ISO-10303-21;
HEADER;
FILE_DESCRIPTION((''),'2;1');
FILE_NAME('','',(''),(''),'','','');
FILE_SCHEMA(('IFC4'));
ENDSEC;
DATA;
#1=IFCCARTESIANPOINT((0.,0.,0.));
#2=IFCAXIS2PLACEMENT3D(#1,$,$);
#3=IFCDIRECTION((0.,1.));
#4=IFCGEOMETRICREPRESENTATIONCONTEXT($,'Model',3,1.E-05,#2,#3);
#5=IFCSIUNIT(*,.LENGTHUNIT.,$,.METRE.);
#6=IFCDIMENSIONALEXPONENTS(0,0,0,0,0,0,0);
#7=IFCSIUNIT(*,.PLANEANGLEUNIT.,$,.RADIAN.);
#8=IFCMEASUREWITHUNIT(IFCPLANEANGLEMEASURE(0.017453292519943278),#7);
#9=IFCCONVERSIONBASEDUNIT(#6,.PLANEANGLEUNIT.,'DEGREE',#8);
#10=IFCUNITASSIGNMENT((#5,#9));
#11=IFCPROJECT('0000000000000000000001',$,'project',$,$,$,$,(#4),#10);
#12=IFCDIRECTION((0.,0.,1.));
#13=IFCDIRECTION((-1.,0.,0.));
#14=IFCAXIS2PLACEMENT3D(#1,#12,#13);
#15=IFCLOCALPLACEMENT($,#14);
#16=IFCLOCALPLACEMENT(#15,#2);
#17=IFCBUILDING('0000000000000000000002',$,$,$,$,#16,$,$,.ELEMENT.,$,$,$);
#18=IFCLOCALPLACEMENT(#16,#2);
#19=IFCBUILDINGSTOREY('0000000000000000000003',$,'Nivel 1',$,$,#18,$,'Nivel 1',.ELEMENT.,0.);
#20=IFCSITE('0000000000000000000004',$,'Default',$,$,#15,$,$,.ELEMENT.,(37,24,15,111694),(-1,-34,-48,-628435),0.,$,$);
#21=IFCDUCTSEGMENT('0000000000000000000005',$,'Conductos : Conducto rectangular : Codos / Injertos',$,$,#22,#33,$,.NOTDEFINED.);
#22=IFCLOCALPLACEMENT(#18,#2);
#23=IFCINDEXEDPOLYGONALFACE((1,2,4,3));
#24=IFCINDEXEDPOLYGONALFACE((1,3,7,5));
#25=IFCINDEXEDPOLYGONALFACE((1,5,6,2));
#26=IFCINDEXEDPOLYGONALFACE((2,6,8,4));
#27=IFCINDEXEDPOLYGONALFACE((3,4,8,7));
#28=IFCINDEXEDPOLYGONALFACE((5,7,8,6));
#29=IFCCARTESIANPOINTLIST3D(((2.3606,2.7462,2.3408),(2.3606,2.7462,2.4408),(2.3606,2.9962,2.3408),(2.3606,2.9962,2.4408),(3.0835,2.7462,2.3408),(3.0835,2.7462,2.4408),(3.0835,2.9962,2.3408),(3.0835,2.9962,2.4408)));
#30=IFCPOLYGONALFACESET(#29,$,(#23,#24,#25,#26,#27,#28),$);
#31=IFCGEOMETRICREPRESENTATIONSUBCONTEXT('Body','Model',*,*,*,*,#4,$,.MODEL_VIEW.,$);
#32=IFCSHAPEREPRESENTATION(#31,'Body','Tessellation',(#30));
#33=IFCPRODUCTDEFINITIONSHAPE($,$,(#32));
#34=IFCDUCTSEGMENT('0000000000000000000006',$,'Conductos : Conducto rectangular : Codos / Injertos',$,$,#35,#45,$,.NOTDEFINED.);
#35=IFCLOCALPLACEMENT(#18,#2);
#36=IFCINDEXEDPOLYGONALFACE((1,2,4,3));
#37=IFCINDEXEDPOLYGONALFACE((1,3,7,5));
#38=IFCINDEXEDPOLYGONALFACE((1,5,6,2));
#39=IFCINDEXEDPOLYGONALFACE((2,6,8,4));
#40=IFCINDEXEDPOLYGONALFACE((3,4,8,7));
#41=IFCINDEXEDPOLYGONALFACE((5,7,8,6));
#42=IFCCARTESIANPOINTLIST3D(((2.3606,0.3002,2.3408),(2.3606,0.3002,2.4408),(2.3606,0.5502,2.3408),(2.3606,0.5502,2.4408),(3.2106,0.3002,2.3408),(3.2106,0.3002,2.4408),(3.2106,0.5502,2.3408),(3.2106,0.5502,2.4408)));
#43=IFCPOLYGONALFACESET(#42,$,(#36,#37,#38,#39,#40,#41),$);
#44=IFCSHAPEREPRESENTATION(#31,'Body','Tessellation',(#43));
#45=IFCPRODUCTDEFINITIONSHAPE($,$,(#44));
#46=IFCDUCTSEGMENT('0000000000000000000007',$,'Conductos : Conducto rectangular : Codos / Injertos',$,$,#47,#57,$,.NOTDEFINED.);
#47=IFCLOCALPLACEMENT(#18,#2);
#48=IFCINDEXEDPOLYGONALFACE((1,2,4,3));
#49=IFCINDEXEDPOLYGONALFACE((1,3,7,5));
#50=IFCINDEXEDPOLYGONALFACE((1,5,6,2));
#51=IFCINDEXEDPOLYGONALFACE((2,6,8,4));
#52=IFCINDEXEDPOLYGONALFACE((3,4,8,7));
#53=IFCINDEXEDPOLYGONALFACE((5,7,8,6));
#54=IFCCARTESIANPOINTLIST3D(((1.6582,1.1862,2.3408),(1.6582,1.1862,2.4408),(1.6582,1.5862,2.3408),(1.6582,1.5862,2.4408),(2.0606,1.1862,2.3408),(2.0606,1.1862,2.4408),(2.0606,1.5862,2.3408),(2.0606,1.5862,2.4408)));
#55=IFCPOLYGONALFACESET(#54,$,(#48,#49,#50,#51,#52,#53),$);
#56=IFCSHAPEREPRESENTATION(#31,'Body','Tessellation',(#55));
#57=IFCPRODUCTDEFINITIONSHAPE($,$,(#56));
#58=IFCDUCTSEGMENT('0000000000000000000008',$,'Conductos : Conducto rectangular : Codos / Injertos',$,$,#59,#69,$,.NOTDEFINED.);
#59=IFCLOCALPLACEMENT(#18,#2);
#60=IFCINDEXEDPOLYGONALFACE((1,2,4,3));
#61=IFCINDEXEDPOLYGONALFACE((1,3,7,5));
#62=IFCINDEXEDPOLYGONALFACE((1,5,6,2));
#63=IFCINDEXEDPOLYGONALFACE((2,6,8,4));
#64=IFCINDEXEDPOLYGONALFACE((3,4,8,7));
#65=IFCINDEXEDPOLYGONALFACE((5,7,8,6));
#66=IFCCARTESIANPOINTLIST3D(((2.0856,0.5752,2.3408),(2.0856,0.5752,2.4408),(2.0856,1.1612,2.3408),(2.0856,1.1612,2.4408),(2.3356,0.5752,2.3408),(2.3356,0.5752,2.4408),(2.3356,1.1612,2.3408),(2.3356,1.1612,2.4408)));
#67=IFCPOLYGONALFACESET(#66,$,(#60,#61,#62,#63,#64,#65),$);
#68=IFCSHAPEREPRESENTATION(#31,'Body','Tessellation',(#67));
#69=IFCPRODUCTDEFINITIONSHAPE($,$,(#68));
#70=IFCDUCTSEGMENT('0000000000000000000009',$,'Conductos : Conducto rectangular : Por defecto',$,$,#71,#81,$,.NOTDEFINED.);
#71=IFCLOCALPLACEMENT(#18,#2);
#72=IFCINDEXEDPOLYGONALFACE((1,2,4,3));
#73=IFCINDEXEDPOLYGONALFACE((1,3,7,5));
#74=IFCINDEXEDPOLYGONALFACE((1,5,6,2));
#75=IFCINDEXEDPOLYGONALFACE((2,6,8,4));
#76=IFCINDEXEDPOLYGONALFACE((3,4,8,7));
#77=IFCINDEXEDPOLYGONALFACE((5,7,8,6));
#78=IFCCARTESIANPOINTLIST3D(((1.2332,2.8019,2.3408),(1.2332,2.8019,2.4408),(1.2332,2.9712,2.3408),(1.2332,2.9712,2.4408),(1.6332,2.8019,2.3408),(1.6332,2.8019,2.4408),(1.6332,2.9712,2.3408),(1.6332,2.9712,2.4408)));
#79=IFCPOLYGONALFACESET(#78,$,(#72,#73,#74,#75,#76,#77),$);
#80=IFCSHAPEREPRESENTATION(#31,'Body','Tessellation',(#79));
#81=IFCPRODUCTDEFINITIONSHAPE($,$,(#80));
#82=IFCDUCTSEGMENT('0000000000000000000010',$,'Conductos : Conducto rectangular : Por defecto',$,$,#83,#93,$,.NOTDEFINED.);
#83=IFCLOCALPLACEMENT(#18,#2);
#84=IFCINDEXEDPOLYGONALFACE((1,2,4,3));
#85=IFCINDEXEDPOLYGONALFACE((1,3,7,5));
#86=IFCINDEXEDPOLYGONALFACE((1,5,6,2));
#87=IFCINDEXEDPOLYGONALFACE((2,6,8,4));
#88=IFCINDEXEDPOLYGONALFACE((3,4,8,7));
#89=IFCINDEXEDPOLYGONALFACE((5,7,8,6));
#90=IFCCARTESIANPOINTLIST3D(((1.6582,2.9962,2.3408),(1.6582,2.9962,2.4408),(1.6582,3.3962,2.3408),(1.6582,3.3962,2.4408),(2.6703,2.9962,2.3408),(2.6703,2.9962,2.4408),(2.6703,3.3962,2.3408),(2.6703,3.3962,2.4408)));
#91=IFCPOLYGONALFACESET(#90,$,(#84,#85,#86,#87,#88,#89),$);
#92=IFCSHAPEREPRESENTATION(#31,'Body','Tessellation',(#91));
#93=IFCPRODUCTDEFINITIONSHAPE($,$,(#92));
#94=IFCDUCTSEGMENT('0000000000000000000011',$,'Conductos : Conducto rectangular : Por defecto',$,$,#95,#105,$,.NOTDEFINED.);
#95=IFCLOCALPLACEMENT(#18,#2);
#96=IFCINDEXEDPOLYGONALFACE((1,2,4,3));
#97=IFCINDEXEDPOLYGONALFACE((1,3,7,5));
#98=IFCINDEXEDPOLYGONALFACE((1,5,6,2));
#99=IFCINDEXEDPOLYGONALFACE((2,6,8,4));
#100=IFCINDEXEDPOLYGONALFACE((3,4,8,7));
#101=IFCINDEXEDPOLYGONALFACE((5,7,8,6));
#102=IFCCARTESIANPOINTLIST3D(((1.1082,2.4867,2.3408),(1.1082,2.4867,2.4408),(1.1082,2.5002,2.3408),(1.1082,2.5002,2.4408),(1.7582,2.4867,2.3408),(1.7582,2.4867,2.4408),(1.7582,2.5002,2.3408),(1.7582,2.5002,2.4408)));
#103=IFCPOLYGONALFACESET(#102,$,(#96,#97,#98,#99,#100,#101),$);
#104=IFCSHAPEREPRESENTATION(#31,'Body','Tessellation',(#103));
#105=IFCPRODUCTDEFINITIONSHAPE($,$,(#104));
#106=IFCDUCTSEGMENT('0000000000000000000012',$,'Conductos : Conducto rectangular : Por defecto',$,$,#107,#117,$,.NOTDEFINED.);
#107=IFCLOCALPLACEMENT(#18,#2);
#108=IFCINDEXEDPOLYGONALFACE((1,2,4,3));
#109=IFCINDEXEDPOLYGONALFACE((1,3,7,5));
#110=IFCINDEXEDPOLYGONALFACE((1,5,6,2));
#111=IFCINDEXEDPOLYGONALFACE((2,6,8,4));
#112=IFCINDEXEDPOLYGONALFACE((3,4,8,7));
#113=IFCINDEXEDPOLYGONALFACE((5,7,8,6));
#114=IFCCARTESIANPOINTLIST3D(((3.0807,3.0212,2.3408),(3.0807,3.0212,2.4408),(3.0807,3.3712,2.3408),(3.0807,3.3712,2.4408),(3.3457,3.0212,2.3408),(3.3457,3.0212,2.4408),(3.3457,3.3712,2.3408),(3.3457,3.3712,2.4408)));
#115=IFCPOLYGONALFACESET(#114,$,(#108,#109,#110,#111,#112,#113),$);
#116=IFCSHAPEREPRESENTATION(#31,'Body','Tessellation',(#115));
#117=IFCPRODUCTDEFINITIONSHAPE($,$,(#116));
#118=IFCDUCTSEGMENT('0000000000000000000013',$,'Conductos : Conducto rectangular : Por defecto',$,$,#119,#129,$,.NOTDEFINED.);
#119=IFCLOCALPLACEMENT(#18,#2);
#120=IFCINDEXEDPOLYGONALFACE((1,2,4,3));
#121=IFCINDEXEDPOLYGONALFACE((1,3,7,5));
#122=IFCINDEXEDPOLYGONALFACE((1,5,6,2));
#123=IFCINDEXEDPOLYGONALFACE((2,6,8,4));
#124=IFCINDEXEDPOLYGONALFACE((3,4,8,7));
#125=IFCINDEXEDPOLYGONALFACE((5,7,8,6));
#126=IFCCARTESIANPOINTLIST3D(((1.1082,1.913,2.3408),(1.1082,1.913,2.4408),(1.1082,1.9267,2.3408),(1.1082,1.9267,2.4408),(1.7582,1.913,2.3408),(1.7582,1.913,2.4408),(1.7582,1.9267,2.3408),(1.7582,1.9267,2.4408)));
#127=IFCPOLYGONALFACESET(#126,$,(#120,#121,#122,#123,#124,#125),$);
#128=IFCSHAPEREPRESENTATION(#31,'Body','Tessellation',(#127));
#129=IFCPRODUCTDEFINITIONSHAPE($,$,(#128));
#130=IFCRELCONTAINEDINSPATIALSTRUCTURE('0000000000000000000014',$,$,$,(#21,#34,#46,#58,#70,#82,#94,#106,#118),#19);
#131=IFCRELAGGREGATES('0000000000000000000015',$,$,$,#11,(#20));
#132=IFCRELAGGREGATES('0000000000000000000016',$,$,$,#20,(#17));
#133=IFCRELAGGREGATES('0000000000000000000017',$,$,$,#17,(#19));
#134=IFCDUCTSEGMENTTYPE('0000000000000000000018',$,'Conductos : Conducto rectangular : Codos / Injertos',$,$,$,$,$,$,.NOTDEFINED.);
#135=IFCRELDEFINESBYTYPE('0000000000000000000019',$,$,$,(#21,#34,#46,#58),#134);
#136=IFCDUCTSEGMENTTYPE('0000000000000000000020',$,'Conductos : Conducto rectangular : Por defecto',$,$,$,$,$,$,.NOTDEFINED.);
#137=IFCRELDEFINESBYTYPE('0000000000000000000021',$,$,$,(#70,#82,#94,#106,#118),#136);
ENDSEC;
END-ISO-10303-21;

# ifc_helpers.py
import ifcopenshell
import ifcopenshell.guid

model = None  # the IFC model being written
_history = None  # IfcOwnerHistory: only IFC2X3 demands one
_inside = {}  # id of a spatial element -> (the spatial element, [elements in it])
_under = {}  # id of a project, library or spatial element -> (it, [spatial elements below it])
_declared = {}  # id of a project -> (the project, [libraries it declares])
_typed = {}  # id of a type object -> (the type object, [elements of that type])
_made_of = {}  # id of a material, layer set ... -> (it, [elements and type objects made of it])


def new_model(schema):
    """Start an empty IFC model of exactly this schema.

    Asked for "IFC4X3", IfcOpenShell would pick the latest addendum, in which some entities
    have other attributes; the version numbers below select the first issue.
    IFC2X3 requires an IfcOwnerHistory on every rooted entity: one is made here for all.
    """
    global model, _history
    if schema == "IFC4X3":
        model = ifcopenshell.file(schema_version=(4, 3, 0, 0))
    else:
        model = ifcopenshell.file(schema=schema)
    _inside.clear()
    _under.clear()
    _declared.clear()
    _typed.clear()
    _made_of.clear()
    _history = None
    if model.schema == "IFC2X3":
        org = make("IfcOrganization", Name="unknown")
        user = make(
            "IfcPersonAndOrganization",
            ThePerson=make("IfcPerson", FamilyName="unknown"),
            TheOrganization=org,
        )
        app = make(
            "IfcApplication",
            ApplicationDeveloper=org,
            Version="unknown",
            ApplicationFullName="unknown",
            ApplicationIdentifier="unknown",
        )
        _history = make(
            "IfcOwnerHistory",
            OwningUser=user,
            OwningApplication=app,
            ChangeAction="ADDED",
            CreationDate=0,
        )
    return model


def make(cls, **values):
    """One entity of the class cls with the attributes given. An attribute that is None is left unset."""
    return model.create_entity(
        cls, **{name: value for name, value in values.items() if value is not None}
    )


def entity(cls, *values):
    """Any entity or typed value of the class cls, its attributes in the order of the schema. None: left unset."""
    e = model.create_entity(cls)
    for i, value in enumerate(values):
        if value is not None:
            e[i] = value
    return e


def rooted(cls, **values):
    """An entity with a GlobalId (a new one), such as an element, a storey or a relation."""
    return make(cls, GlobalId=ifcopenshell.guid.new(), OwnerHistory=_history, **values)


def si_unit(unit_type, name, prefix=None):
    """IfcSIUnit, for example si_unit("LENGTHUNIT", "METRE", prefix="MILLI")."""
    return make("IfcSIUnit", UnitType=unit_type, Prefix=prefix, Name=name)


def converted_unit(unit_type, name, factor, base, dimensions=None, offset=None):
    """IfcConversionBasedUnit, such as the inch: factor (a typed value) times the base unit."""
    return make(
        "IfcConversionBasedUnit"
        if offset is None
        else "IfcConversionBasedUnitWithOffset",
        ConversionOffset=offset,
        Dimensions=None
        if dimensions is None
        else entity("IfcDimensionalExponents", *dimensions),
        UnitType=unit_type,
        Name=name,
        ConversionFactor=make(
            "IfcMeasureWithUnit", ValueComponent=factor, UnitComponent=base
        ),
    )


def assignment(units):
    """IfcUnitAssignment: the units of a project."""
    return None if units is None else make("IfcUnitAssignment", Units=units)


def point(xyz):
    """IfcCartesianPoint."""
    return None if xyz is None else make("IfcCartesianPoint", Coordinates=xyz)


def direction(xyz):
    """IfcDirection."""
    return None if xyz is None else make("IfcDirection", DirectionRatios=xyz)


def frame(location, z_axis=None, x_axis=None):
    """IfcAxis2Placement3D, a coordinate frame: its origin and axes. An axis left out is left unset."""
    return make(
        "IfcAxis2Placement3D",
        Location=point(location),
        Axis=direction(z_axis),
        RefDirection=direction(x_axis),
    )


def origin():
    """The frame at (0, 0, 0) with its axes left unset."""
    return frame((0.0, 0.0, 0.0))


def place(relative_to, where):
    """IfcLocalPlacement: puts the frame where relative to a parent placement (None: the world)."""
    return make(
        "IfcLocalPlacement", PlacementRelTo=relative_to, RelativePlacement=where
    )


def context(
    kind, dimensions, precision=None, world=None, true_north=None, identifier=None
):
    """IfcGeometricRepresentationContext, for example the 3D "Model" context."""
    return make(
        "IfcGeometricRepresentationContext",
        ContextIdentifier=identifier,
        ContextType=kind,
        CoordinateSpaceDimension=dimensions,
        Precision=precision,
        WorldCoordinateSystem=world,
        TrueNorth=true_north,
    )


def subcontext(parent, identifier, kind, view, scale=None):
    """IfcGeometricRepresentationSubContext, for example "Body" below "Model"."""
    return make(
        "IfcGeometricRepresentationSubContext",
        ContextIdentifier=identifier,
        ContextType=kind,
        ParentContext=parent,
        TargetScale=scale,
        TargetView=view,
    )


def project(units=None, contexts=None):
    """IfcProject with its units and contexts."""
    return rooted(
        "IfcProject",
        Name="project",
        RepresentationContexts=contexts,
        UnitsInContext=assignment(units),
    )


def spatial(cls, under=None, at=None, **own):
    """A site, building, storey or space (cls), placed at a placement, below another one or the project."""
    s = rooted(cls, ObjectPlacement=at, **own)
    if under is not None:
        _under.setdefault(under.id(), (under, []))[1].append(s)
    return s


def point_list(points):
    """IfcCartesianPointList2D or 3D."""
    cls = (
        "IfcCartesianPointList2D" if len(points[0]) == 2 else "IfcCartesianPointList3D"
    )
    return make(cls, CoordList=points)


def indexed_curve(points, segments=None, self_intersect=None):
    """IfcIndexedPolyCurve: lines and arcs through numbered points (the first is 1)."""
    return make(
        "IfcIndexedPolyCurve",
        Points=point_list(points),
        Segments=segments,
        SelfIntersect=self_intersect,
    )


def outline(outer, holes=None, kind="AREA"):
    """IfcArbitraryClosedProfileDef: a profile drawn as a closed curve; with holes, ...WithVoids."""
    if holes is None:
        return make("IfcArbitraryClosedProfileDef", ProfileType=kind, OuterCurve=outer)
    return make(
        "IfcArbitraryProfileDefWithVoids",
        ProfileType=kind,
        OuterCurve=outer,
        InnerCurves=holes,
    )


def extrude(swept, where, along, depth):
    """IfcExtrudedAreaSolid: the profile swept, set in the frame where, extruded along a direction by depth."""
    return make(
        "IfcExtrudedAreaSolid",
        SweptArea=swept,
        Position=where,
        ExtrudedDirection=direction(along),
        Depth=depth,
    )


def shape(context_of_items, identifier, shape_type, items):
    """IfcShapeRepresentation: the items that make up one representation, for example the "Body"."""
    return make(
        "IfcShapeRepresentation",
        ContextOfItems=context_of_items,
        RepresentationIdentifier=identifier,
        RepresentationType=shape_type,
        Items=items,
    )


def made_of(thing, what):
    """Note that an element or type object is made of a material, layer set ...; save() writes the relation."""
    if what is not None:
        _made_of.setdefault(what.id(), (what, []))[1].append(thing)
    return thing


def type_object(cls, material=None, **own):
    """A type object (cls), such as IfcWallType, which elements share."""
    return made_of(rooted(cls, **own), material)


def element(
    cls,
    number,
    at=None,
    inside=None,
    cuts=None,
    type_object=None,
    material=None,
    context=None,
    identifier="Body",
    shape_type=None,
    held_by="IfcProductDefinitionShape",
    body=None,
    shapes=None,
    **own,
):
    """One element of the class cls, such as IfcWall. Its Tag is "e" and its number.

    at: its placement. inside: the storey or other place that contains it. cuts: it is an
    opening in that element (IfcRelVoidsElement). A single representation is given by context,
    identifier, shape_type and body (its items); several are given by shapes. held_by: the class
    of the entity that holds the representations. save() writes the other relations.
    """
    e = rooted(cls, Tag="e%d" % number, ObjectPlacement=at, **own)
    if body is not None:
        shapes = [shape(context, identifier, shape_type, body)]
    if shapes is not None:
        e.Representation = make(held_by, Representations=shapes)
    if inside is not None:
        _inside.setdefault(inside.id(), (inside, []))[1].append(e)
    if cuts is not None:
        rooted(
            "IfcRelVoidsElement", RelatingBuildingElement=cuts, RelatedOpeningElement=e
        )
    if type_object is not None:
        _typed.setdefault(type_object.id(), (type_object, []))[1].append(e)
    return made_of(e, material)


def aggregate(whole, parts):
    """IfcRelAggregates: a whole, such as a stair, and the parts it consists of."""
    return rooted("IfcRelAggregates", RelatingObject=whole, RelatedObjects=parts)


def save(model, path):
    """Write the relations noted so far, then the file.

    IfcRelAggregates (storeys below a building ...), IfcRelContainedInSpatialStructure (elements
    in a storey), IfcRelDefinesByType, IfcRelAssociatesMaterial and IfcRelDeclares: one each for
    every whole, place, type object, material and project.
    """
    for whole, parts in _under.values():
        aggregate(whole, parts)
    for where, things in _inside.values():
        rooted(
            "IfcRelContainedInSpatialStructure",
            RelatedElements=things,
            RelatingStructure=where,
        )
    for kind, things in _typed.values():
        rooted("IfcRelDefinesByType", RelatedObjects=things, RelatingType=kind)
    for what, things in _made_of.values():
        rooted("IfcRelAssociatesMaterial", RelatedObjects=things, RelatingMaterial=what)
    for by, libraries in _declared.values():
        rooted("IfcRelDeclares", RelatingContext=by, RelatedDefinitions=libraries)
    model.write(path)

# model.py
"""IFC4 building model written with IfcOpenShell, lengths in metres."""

from ifc_helpers import new_model, entity, si_unit, converted_unit, direction, frame, origin, place, context, subcontext, project, spatial, indexed_curve, outline, extrude, type_object, element, save


model = new_model("IFC4")

# Units and contexts
model_context = context("Model", 3, precision=1e-05, world=origin(), true_north=direction((0.0, 1.0)))
body_context = subcontext(model_context, "Body", "Model", "MODEL_VIEW")
ifc_project = project(units=[si_unit("LENGTHUNIT", "METRE"), converted_unit("PLANEANGLEUNIT", "DEGREE", entity("IfcPlaneAngleMeasure", 0.017453292519943278), si_unit("PLANEANGLEUNIT", "RADIAN"), dimensions=[0, 0, 0, 0, 0, 0, 0])], contexts=[model_context])

# Site, building, storey
site_placement = place(None, frame((0.0, 0.0, 0.0), z_axis=(0.0, 0.0, 1.0), x_axis=(-1.0, 0.0, 0.0)))
site = spatial("IfcSite", under=ifc_project, at=site_placement, Name="Default", CompositionType="ELEMENT", RefLatitude=(37, 24, 15, 111694), RefLongitude=(-1, -34, -48, -628435), RefElevation=0.0)
building_placement = place(site_placement, origin())
building = spatial("IfcBuilding", under=site, at=building_placement, CompositionType="ELEMENT")
storey_placement = place(building_placement, origin())
storey = spatial("IfcBuildingStorey", under=building, at=storey_placement, Name="Nivel 1", LongName="Nivel 1", CompositionType="ELEMENT", Elevation=0.0)

# Duct segments
duct_segment_type_1 = type_object("IfcDuctSegmentType", Name="Conductos : Conducto rectangular : Codos / Injertos", PredefinedType="NOTDEFINED")
duct_segment_1_placement = place(storey_placement, origin())
element("IfcDuctSegment", 1, at=duct_segment_1_placement, inside=storey, type_object=duct_segment_type_1, Name="Conductos : Conducto rectangular : Codos / Injertos", PredefinedType="NOTDEFINED", context=body_context, shape_type="SweptSolid", body=[
    extrude(outline(indexed_curve([(-0.3614, -0.125), (0.3614, -0.125), (0.3614, 0.125), (-0.3614, 0.125), (-0.3614, -0.125)], self_intersect=False)), frame((2.7221, 2.8712, 2.3408)), (0.0, 0.0, 1.0), 0.1),
])
duct_segment_2_placement = place(storey_placement, origin())
element("IfcDuctSegment", 2, at=duct_segment_2_placement, inside=storey, type_object=duct_segment_type_1, Name="Conductos : Conducto rectangular : Codos / Injertos", PredefinedType="NOTDEFINED", context=body_context, shape_type="SweptSolid", body=[
    extrude(outline(indexed_curve([(-0.425, -0.125), (0.425, -0.125), (0.425, 0.125), (-0.425, 0.125), (-0.425, -0.125)], self_intersect=False)), frame((2.7856, 0.4252, 2.3408)), (0.0, 0.0, 1.0), 0.1),
])
duct_segment_3_placement = place(storey_placement, origin())
element("IfcDuctSegment", 3, at=duct_segment_3_placement, inside=storey, type_object=duct_segment_type_1, Name="Conductos : Conducto rectangular : Codos / Injertos", PredefinedType="NOTDEFINED", context=body_context, shape_type="SweptSolid", body=[
    extrude(outline(indexed_curve([(-0.2012, -0.2), (0.2012, -0.2), (0.2012, 0.2), (-0.2012, 0.2), (-0.2012, -0.2)], self_intersect=False)), frame((1.8594, 1.3862, 2.3408), z_axis=(0.0, 0.0, 1.0), x_axis=(-1.0, 0.0, 0.0)), (0.0, 0.0, 1.0), 0.1),
])
duct_segment_4_placement = place(storey_placement, origin())
element("IfcDuctSegment", 4, at=duct_segment_4_placement, inside=storey, type_object=duct_segment_type_1, Name="Conductos : Conducto rectangular : Codos / Injertos", PredefinedType="NOTDEFINED", context=body_context, shape_type="SweptSolid", body=[
    extrude(outline(indexed_curve([(-0.293, -0.125), (0.293, -0.125), (0.293, 0.125), (-0.293, 0.125), (-0.293, -0.125)], self_intersect=False)), frame((2.2106, 0.8682, 2.3408), z_axis=(0.0, 0.0, 1.0), x_axis=(0.0, 1.0, 0.0)), (0.0, 0.0, 1.0), 0.1),
])
duct_segment_type_2 = type_object("IfcDuctSegmentType", Name="Conductos : Conducto rectangular : Por defecto", PredefinedType="NOTDEFINED")
duct_segment_5_placement = place(storey_placement, origin())
element("IfcDuctSegment", 5, at=duct_segment_5_placement, inside=storey, type_object=duct_segment_type_2, Name="Conductos : Conducto rectangular : Por defecto", PredefinedType="NOTDEFINED", context=body_context, shape_type="SweptSolid", body=[
    extrude(outline(indexed_curve([(-0.0846, -0.2), (0.0846, -0.2), (0.0846, 0.2), (-0.0846, 0.2), (-0.0846, -0.2)], self_intersect=False)), frame((1.4332, 2.8866, 2.3408), z_axis=(0.0, 0.0, 1.0), x_axis=(0.0, -1.0, 0.0)), (0.0, 0.0, 1.0), 0.1),
])
duct_segment_6_placement = place(storey_placement, origin())
element("IfcDuctSegment", 6, at=duct_segment_6_placement, inside=storey, type_object=duct_segment_type_2, Name="Conductos : Conducto rectangular : Por defecto", PredefinedType="NOTDEFINED", context=body_context, shape_type="SweptSolid", body=[
    extrude(outline(indexed_curve([(-0.5061, -0.2), (0.5061, -0.2), (0.5061, 0.2), (-0.5061, 0.2), (-0.5061, -0.2)], self_intersect=False)), frame((2.1643, 3.1962, 2.3408)), (0.0, 0.0, 1.0), 0.1),
])
duct_segment_7_placement = place(storey_placement, origin())
element("IfcDuctSegment", 7, at=duct_segment_7_placement, inside=storey, type_object=duct_segment_type_2, Name="Conductos : Conducto rectangular : Por defecto", PredefinedType="NOTDEFINED", context=body_context, shape_type="SweptSolid", body=[
    extrude(outline(indexed_curve([(-0.0067, -0.325), (0.0067, -0.325), (0.0067, 0.325), (-0.0067, 0.325), (-0.0067, -0.325)], self_intersect=False)), frame((1.4332, 2.4934, 2.3408), z_axis=(0.0, 0.0, 1.0), x_axis=(0.0, -1.0, 0.0)), (0.0, 0.0, 1.0), 0.1),
])
duct_segment_8_placement = place(storey_placement, origin())
element("IfcDuctSegment", 8, at=duct_segment_8_placement, inside=storey, type_object=duct_segment_type_2, Name="Conductos : Conducto rectangular : Por defecto", PredefinedType="NOTDEFINED", context=body_context, shape_type="SweptSolid", body=[
    extrude(outline(indexed_curve([(-0.1325, -0.175), (0.1325, -0.175), (0.1325, 0.175), (-0.1325, 0.175), (-0.1325, -0.175)], self_intersect=False)), frame((3.2132, 3.1962, 2.3408)), (0.0, 0.0, 1.0), 0.1),
])
duct_segment_9_placement = place(storey_placement, origin())
element("IfcDuctSegment", 9, at=duct_segment_9_placement, inside=storey, type_object=duct_segment_type_2, Name="Conductos : Conducto rectangular : Por defecto", PredefinedType="NOTDEFINED", context=body_context, shape_type="SweptSolid", body=[
    extrude(outline(indexed_curve([(-0.0068, -0.325), (0.0068, -0.325), (0.0068, 0.325), (-0.0068, 0.325), (-0.0068, -0.325)], self_intersect=False)), frame((1.4332, 1.9199, 2.3408), z_axis=(0.0, 0.0, 1.0), x_axis=(0.0, 1.0, 0.0)), (0.0, 0.0, 1.0), 0.1),
])

save(model, "model.ifc")
